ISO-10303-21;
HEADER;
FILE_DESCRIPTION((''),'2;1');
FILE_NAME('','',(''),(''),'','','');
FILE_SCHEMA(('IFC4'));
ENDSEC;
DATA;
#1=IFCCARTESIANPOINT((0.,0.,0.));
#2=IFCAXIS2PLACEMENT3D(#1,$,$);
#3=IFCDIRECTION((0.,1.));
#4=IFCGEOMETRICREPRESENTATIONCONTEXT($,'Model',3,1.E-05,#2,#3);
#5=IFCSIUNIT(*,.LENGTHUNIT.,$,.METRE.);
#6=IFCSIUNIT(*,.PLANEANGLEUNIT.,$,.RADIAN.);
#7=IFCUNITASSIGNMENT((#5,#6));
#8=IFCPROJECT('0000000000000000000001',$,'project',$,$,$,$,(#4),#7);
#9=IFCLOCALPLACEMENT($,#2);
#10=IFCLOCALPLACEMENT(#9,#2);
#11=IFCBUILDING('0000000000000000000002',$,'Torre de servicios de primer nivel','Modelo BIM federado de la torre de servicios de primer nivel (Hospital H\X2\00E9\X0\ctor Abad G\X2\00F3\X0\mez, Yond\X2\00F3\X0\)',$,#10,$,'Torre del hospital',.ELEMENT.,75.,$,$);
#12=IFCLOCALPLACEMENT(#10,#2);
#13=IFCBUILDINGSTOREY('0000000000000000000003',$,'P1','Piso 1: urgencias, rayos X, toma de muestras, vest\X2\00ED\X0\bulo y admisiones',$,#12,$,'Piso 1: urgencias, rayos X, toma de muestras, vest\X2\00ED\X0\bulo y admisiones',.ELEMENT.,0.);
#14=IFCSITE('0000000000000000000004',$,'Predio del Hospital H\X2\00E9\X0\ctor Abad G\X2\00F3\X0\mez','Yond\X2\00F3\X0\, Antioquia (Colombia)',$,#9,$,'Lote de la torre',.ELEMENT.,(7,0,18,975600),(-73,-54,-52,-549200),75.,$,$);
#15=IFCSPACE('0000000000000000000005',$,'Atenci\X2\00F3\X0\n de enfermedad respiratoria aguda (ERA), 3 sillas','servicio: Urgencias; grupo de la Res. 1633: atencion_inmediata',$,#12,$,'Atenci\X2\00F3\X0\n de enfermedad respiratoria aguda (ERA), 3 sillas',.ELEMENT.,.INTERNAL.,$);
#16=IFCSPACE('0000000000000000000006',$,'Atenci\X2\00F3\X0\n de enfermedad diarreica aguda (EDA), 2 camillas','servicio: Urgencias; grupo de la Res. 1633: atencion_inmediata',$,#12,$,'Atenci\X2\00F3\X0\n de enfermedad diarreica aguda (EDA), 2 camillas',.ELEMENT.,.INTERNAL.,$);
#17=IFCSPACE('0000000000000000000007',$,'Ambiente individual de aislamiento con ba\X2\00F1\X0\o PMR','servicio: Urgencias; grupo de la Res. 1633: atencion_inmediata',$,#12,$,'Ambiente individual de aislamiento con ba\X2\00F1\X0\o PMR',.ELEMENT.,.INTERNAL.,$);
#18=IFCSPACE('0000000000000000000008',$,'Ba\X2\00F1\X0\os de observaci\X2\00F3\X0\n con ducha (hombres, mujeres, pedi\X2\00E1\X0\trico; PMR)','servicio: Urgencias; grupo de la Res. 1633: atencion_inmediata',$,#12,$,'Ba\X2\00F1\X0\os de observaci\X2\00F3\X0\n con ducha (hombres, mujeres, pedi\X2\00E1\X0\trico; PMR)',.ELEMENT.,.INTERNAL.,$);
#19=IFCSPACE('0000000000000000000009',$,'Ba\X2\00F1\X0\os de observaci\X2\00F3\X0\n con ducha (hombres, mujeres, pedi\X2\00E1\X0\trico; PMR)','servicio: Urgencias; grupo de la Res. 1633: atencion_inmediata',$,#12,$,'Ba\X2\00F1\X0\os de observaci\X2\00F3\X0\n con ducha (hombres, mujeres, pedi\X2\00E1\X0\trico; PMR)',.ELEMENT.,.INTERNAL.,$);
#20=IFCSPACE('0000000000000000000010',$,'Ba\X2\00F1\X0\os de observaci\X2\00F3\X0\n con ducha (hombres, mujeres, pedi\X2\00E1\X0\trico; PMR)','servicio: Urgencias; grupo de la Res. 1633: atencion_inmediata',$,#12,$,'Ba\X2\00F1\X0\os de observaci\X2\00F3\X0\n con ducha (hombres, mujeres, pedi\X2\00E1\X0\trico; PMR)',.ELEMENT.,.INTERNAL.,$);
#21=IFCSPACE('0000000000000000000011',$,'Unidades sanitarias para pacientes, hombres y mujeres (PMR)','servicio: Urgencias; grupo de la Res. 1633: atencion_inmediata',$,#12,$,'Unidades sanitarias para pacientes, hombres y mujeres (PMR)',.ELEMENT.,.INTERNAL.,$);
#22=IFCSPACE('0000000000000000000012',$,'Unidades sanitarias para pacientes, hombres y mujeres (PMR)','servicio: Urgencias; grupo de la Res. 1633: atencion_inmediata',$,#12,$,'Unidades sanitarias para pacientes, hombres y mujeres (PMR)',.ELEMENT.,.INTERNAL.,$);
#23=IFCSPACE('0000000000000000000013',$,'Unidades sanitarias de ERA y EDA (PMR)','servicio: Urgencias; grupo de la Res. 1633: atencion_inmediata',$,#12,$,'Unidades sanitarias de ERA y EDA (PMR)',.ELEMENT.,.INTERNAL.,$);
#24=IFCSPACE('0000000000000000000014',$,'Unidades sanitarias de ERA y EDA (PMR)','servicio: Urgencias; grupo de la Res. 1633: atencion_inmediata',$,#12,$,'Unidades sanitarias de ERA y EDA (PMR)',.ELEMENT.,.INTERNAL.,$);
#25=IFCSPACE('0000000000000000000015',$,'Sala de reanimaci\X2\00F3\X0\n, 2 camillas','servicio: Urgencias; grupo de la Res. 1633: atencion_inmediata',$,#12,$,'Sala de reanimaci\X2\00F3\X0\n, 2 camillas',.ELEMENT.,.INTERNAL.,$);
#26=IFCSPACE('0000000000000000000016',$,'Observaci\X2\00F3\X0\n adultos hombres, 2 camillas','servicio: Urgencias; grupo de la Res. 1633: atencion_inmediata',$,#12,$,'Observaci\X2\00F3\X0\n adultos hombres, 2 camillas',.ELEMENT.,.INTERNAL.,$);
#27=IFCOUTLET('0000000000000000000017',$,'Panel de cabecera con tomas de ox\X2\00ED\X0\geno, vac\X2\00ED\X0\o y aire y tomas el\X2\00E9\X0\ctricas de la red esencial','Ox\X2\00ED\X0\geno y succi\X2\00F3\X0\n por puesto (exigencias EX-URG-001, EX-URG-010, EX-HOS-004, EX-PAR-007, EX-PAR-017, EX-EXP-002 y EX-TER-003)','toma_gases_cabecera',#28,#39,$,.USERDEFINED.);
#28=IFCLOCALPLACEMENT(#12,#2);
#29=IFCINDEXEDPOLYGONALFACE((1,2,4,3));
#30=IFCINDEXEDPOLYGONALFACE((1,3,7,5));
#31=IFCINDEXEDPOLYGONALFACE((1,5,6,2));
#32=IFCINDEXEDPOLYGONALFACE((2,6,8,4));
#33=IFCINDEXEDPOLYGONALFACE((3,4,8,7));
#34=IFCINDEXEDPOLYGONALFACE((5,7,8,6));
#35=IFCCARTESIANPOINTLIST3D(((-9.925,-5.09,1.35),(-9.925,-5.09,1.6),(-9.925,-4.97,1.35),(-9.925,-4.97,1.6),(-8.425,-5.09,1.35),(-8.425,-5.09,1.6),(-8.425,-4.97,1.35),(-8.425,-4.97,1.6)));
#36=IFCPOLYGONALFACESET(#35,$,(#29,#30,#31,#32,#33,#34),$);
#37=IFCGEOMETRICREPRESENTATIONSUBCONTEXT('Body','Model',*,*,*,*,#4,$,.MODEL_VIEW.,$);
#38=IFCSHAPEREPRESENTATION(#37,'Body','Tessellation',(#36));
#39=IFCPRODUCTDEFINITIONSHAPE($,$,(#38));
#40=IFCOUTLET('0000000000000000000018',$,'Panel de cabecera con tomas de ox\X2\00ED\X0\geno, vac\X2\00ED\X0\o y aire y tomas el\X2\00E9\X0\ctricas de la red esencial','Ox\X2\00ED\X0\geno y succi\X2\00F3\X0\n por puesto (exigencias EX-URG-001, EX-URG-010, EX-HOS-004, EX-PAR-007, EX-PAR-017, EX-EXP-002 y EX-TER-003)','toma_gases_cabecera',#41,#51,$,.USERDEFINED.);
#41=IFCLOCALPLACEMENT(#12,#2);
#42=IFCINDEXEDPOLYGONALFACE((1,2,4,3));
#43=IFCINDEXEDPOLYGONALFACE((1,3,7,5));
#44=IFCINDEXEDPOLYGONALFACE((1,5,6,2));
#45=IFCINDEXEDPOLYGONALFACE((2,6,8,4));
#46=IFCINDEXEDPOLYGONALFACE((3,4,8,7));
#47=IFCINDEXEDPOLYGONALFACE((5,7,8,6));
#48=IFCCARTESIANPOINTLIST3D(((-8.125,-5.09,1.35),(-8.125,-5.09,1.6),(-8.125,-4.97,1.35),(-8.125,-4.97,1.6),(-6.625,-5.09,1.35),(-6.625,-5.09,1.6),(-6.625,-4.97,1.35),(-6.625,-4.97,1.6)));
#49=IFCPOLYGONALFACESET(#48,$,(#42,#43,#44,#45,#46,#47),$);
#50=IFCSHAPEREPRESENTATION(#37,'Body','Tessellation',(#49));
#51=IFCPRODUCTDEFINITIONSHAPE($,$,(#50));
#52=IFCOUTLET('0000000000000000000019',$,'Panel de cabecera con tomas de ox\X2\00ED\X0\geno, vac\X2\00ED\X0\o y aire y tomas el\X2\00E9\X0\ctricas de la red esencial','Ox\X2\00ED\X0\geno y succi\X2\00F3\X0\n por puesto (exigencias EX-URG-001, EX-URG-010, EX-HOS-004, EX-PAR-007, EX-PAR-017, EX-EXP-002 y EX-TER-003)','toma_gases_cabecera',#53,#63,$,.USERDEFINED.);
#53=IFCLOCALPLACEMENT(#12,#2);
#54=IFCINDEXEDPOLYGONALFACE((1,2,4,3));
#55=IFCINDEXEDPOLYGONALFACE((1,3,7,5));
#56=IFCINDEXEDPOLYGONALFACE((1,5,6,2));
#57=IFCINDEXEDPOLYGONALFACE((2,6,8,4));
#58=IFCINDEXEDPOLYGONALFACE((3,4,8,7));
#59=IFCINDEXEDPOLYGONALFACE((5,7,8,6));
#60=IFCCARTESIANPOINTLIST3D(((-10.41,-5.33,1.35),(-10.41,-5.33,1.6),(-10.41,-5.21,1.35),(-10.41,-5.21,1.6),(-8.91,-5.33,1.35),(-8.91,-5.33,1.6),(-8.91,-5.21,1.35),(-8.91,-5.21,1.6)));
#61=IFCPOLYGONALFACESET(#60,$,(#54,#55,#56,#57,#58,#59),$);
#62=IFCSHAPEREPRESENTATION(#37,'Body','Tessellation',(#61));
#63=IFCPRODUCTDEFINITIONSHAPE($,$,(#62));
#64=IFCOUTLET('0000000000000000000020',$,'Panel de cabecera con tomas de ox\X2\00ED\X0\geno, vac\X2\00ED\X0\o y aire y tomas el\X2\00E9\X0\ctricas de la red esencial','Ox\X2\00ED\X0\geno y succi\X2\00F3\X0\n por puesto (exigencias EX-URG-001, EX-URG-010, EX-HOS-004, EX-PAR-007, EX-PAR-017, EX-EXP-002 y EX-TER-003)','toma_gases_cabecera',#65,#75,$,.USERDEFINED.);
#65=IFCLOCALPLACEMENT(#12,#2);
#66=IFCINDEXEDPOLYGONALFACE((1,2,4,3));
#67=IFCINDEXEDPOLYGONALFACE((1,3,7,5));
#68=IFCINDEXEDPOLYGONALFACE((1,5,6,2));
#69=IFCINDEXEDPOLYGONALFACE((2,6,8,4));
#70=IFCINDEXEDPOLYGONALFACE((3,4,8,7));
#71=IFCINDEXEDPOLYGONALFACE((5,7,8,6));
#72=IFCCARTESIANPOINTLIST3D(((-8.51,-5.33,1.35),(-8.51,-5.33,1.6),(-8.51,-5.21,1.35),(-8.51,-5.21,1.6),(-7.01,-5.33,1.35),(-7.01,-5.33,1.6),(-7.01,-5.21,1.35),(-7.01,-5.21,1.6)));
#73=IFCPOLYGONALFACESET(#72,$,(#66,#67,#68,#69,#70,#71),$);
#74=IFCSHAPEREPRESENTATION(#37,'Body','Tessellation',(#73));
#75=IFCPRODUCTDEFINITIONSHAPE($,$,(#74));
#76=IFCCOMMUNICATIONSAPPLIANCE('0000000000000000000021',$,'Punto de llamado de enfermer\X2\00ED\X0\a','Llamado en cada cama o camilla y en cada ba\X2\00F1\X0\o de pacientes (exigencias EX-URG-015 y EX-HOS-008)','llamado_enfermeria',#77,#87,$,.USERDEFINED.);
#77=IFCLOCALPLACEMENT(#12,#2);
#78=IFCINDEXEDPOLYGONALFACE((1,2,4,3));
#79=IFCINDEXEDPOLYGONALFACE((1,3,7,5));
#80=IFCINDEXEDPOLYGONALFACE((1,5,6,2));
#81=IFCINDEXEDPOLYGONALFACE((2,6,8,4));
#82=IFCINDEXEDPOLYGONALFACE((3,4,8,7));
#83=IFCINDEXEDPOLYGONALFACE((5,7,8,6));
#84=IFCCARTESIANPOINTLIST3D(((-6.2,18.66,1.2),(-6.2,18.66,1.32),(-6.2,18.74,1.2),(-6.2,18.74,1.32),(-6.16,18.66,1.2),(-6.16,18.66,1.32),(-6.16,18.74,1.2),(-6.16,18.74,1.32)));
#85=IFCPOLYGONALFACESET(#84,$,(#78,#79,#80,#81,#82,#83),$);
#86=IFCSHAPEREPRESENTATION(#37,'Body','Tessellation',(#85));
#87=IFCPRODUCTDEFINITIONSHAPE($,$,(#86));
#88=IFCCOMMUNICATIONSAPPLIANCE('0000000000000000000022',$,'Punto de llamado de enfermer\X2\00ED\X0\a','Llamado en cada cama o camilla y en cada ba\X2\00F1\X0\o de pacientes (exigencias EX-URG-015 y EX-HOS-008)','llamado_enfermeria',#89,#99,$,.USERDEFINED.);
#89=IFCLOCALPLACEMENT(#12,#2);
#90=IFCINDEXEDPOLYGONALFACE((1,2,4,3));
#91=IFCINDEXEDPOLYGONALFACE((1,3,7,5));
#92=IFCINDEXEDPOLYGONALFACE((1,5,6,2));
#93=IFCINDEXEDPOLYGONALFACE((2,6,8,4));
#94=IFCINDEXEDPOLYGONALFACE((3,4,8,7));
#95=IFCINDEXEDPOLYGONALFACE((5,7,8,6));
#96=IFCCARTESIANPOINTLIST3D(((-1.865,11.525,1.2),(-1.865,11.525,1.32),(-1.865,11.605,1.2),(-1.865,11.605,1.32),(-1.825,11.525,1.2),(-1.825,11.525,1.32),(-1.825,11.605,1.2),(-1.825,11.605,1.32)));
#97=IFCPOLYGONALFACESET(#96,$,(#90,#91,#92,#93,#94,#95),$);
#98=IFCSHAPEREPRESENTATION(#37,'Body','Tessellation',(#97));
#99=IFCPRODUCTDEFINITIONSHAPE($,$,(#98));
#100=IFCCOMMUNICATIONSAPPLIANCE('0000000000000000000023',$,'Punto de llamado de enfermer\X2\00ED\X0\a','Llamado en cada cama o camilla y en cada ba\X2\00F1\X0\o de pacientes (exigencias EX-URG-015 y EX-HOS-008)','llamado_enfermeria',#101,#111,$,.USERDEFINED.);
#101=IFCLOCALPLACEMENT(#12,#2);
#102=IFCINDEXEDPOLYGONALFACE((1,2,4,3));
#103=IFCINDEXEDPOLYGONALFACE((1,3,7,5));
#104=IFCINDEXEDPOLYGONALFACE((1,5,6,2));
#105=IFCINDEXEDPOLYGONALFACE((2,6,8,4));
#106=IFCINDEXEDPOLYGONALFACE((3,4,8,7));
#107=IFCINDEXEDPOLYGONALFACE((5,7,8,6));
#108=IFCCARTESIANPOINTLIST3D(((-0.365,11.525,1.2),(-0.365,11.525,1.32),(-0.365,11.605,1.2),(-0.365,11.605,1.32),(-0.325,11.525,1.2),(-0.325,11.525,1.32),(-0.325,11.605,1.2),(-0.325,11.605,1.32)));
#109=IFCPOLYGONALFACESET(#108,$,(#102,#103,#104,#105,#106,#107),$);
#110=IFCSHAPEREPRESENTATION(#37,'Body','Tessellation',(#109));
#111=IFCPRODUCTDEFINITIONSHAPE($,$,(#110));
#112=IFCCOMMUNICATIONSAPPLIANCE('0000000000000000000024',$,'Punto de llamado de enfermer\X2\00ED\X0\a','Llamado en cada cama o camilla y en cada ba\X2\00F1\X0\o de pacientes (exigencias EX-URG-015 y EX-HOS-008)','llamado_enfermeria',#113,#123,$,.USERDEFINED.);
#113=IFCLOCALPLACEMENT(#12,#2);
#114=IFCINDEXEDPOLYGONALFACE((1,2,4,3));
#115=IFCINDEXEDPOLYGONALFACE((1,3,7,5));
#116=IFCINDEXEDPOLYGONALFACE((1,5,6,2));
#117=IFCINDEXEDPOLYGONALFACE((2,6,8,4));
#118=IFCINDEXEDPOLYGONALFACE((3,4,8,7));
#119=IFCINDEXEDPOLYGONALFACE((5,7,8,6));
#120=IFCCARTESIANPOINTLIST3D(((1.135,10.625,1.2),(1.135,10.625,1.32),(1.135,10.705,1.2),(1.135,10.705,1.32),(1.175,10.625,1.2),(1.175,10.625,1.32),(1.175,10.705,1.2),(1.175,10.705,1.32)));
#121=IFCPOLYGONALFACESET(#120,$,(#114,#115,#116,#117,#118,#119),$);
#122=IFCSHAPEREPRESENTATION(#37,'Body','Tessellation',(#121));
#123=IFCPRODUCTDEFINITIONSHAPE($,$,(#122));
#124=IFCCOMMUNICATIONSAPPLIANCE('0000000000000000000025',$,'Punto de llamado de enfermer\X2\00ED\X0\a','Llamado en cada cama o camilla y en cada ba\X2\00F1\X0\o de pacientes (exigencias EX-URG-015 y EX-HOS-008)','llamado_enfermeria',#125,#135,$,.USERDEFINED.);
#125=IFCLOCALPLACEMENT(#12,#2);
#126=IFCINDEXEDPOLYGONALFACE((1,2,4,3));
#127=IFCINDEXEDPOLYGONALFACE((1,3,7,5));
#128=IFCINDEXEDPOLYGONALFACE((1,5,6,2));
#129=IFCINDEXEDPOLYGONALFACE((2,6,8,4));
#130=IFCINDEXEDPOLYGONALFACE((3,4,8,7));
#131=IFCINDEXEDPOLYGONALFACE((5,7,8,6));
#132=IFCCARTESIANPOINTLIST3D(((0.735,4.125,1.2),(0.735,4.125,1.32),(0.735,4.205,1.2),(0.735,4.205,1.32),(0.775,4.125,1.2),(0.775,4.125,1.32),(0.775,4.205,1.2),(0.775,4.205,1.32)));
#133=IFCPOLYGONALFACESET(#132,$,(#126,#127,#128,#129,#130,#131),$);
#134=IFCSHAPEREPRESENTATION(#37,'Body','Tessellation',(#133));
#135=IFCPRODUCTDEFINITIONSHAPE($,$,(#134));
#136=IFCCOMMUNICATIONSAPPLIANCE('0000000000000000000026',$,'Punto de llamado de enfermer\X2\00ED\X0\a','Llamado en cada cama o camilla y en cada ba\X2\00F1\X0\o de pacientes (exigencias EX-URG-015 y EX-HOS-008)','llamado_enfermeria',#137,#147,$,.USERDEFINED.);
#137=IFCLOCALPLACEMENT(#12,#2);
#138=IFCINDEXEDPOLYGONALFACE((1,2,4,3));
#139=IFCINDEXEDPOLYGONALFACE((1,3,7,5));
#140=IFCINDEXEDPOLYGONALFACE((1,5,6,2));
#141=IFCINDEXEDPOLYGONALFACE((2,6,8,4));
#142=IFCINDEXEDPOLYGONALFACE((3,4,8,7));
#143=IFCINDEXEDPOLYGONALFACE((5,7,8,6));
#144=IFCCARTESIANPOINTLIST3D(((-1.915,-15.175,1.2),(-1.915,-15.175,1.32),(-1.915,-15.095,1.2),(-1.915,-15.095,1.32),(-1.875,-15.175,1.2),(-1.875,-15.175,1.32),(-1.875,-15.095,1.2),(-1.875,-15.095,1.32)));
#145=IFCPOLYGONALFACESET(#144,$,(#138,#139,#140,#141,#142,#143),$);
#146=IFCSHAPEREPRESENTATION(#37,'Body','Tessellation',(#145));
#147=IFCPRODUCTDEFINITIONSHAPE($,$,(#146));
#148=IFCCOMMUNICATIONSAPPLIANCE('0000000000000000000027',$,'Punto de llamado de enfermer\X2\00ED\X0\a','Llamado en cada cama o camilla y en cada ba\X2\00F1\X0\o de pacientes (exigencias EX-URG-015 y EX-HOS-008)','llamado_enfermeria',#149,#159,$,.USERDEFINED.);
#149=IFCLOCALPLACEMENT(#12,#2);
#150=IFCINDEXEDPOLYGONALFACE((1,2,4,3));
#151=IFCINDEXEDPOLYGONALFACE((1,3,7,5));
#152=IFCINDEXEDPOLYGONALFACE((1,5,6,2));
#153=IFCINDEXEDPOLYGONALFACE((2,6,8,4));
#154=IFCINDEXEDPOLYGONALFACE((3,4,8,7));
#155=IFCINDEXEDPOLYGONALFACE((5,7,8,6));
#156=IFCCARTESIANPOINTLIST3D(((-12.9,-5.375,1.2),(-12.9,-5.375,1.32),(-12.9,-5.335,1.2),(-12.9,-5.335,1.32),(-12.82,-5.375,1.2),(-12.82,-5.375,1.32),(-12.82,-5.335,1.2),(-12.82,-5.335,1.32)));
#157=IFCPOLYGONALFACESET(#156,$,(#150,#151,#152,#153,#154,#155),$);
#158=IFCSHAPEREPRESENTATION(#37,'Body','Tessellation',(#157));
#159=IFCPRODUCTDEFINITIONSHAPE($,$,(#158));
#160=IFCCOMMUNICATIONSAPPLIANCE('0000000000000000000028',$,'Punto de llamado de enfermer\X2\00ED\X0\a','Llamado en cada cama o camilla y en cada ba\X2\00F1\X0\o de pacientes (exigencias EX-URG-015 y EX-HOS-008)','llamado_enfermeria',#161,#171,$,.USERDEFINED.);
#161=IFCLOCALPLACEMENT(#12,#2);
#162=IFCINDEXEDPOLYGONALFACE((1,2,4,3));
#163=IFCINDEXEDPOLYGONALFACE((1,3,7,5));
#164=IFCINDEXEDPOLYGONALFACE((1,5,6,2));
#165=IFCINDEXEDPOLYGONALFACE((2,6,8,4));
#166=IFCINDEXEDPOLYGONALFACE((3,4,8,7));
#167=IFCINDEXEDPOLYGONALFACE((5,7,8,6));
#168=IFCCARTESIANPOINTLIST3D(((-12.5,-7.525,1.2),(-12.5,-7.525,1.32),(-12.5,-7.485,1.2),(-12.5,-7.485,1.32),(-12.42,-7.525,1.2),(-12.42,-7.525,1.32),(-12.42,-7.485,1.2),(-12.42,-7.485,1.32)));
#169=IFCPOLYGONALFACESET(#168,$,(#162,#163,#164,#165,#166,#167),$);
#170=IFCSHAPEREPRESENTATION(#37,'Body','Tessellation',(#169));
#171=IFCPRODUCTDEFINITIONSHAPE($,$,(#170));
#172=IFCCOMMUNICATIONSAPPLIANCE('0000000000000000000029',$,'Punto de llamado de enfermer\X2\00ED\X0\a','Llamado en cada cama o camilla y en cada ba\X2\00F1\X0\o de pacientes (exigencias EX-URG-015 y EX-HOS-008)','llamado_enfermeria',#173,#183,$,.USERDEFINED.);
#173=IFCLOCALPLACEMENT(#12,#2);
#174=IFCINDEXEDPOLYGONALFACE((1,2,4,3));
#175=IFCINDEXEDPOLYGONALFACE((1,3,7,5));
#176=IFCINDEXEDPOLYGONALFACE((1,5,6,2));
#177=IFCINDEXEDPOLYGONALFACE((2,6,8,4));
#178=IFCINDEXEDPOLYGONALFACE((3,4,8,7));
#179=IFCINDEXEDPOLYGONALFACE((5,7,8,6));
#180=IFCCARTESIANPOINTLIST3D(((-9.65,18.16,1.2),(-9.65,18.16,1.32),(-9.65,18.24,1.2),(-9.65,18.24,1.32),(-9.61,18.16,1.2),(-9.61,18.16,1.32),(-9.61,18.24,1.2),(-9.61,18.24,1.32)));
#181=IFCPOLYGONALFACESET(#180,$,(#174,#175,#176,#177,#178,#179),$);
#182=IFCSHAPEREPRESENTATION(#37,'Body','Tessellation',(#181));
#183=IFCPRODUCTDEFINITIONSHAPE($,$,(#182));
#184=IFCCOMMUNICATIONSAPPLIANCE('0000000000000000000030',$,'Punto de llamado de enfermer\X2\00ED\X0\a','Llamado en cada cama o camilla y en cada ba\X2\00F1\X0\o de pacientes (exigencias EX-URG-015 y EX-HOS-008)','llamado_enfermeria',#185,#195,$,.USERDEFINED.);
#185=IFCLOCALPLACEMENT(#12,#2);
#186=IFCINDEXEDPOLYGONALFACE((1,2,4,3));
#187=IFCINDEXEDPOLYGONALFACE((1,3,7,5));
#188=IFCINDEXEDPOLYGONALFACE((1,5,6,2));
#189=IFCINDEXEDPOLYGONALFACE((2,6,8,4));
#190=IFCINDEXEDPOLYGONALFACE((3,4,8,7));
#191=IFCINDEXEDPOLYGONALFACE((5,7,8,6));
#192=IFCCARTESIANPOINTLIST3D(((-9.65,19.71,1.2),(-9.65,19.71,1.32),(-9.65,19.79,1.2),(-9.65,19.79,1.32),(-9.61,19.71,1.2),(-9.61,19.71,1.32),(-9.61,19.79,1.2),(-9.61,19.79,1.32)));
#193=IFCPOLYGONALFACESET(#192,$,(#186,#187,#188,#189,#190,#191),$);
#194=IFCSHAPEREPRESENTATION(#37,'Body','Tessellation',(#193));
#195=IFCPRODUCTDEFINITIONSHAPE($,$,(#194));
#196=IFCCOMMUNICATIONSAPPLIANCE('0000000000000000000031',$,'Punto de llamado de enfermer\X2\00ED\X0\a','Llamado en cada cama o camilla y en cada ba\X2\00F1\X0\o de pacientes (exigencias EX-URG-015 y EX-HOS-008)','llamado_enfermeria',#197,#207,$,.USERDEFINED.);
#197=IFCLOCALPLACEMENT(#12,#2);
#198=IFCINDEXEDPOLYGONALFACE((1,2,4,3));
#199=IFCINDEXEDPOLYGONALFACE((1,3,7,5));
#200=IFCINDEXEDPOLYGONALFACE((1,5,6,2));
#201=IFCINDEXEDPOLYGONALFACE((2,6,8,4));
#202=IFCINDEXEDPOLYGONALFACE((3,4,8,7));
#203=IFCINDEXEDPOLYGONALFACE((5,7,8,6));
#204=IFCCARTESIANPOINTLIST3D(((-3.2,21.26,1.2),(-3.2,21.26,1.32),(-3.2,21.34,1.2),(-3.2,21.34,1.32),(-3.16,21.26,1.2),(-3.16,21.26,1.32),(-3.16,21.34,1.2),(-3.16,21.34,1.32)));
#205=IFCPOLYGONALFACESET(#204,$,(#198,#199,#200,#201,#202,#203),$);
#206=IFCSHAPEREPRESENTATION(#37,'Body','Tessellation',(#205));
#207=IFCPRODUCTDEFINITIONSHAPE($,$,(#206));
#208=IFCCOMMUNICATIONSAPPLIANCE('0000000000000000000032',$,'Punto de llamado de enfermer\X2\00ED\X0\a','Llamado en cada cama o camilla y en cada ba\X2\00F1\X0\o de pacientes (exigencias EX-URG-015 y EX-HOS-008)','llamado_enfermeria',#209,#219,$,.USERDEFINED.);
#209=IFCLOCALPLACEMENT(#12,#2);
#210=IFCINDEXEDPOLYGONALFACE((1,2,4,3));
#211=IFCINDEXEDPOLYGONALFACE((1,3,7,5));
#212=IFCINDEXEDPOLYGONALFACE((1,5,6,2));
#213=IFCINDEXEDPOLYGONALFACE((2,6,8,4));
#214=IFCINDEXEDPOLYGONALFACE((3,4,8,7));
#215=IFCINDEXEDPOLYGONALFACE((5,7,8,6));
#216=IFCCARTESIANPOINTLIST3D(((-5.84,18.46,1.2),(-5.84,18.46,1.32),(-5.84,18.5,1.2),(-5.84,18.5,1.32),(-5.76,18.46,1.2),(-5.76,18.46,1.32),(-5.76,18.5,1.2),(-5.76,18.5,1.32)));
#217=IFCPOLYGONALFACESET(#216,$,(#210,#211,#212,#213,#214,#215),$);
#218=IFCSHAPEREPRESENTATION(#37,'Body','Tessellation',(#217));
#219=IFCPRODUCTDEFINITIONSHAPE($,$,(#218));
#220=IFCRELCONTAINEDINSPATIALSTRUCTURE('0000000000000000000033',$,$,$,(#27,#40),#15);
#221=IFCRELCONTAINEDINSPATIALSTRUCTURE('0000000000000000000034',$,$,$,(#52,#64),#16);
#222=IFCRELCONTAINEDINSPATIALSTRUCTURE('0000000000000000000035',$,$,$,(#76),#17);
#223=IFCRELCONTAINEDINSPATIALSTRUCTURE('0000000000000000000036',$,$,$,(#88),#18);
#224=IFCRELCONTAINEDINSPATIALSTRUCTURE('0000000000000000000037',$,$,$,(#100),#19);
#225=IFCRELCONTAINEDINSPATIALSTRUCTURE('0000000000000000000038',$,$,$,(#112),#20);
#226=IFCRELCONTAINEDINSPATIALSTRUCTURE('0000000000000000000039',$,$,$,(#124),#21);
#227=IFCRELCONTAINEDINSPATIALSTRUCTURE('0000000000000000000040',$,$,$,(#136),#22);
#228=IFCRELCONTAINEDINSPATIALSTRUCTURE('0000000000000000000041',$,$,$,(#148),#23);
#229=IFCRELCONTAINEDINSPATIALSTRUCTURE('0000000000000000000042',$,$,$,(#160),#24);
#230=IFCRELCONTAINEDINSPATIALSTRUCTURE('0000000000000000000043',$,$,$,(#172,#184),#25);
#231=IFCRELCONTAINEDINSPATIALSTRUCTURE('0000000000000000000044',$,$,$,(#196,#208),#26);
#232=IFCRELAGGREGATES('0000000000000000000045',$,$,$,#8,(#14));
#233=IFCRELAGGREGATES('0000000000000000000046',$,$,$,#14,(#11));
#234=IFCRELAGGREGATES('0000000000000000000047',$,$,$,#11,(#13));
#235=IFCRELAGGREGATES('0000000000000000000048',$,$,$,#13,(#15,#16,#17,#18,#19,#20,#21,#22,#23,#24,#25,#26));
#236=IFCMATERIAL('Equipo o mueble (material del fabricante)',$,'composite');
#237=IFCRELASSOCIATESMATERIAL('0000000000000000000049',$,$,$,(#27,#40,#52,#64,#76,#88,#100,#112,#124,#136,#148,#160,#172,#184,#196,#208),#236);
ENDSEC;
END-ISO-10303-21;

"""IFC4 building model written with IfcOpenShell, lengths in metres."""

from ifc_helpers import new_model, si_unit, direction, frame, origin, place, context, subcontext, project, spatial, rectangle, extrude, material, element, save


model = new_model("IFC4")

# Units and contexts
model_context = context("Model", 3, precision=1e-05, world=origin(), true_north=direction((0.0, 1.0)))
body_context = subcontext(model_context, "Body", "Model", "MODEL_VIEW")
ifc_project = project(units=[si_unit("LENGTHUNIT", "METRE"), si_unit("PLANEANGLEUNIT", "RADIAN")], contexts=[model_context])

# Site, building, storey, space
site_placement = place(None, origin())
site = spatial("IfcSite", under=ifc_project, at=site_placement, Name="Predio del Hospital Héctor Abad Gómez", Description="Yondó, Antioquia (Colombia)", LongName="Lote de la torre", CompositionType="ELEMENT", RefLatitude=(7, 0, 18, 975600), RefLongitude=(-73, -54, -52, -549200), RefElevation=75.0)
building_placement = place(site_placement, origin())
building = spatial("IfcBuilding", under=site, at=building_placement, Name="Torre de servicios de primer nivel", Description="Modelo BIM federado de la torre de servicios de primer nivel (Hospital Héctor Abad Gómez, Yondó)", LongName="Torre del hospital", CompositionType="ELEMENT", ElevationOfRefHeight=75.0)
placement = place(building_placement, origin())
storey = spatial("IfcBuildingStorey", under=building, at=placement, Name="P1", Description="Piso 1: urgencias, rayos X, toma de muestras, vestíbulo y admisiones", LongName="Piso 1: urgencias, rayos X, toma de muestras, vestíbulo y admisiones", CompositionType="ELEMENT", Elevation=0.0)
space_1 = spatial("IfcSpace", under=storey, at=placement, Name="Atención de enfermedad respiratoria aguda (ERA), 3 sillas", Description="servicio: Urgencias; grupo de la Res. 1633: atencion_inmediata", LongName="Atención de enfermedad respiratoria aguda (ERA), 3 sillas", CompositionType="ELEMENT", PredefinedType="INTERNAL")

# Outlets
ifc_material = material(Name="Equipo o mueble (material del fabricante)", Category="composite")
element("IfcOutlet", 1, at=placement, inside=space_1, material=ifc_material, Name="Panel de cabecera con tomas de oxígeno, vacío y aire y tomas eléctricas de la red esencial", Description="Oxígeno y succión por puesto (exigencias EX-URG-001, EX-URG-010, EX-HOS-004, EX-PAR-007, EX-PAR-017, EX-EXP-002 y EX-TER-003)", ObjectType="toma_gases_cabecera", PredefinedType="USERDEFINED", context=body_context, shape_type="SweptSolid", body=[
    extrude(rectangle(XDim=1.5, YDim=0.12), frame((-9.175, -5.03, 1.35)), (0.0, 0.0, 1.0), 0.25),
])
element("IfcOutlet", 2, at=placement, inside=space_1, material=ifc_material, Name="Panel de cabecera con tomas de oxígeno, vacío y aire y tomas eléctricas de la red esencial", Description="Oxígeno y succión por puesto (exigencias EX-URG-001, EX-URG-010, EX-HOS-004, EX-PAR-007, EX-PAR-017, EX-EXP-002 y EX-TER-003)", ObjectType="toma_gases_cabecera", PredefinedType="USERDEFINED", context=body_context, shape_type="SweptSolid", body=[
    extrude(rectangle(XDim=1.5, YDim=0.12), frame((-7.375, -5.03, 1.35)), (0.0, 0.0, 1.0), 0.25),
])

# Shared definitions
space_2 = spatial("IfcSpace", under=storey, at=placement, Name="Atención de enfermedad diarreica aguda (EDA), 2 camillas", Description="servicio: Urgencias; grupo de la Res. 1633: atencion_inmediata", LongName="Atención de enfermedad diarreica aguda (EDA), 2 camillas", CompositionType="ELEMENT", PredefinedType="INTERNAL")

# Outlets
element("IfcOutlet", 3, at=placement, inside=space_2, material=ifc_material, Name="Panel de cabecera con tomas de oxígeno, vacío y aire y tomas eléctricas de la red esencial", Description="Oxígeno y succión por puesto (exigencias EX-URG-001, EX-URG-010, EX-HOS-004, EX-PAR-007, EX-PAR-017, EX-EXP-002 y EX-TER-003)", ObjectType="toma_gases_cabecera", PredefinedType="USERDEFINED", context=body_context, shape_type="SweptSolid", body=[
    extrude(rectangle(XDim=1.5, YDim=0.12), frame((-9.66, -5.27, 1.35), z_axis=(0.0, 0.0, 1.0), x_axis=(-1.0, 0.0, 0.0)), (0.0, 0.0, 1.0), 0.25),
])
element("IfcOutlet", 4, at=placement, inside=space_2, material=ifc_material, Name="Panel de cabecera con tomas de oxígeno, vacío y aire y tomas eléctricas de la red esencial", Description="Oxígeno y succión por puesto (exigencias EX-URG-001, EX-URG-010, EX-HOS-004, EX-PAR-007, EX-PAR-017, EX-EXP-002 y EX-TER-003)", ObjectType="toma_gases_cabecera", PredefinedType="USERDEFINED", context=body_context, shape_type="SweptSolid", body=[
    extrude(rectangle(XDim=1.5, YDim=0.12), frame((-7.76, -5.27, 1.35), z_axis=(0.0, 0.0, 1.0), x_axis=(-1.0, 0.0, 0.0)), (0.0, 0.0, 1.0), 0.25),
])

# Shared definitions
space_3 = spatial("IfcSpace", under=storey, at=placement, Name="Ambiente individual de aislamiento con baño PMR", Description="servicio: Urgencias; grupo de la Res. 1633: atencion_inmediata", LongName="Ambiente individual de aislamiento con baño PMR", CompositionType="ELEMENT", PredefinedType="INTERNAL")

# Communications appliance
element("IfcCommunicationsAppliance", 5, at=placement, inside=space_3, material=ifc_material, Name="Punto de llamado de enfermería", Description="Llamado en cada cama o camilla y en cada baño de pacientes (exigencias EX-URG-015 y EX-HOS-008)", ObjectType="llamado_enfermeria", PredefinedType="USERDEFINED", context=body_context, shape_type="SweptSolid", body=[
    extrude(rectangle(XDim=0.08, YDim=0.04), frame((-6.18, 18.7, 1.2), z_axis=(0.0, 0.0, 1.0), x_axis=(0.0, 1.0, 0.0)), (0.0, 0.0, 1.0), 0.12),
])

# Shared definitions
space_4 = spatial("IfcSpace", under=storey, at=placement, Name="Baños de observación con ducha (hombres, mujeres, pediátrico; PMR)", Description="servicio: Urgencias; grupo de la Res. 1633: atencion_inmediata", LongName="Baños de observación con ducha (hombres, mujeres, pediátrico; PMR)", CompositionType="ELEMENT", PredefinedType="INTERNAL")

# Communications appliance
element("IfcCommunicationsAppliance", 6, at=placement, inside=space_4, material=ifc_material, Name="Punto de llamado de enfermería", Description="Llamado en cada cama o camilla y en cada baño de pacientes (exigencias EX-URG-015 y EX-HOS-008)", ObjectType="llamado_enfermeria", PredefinedType="USERDEFINED", context=body_context, shape_type="SweptSolid", body=[
    extrude(rectangle(XDim=0.08, YDim=0.04), frame((-1.845, 11.565, 1.2), z_axis=(0.0, 0.0, 1.0), x_axis=(0.0, 1.0, 0.0)), (0.0, 0.0, 1.0), 0.12),
])

# Shared definitions
space_5 = spatial("IfcSpace", under=storey, at=placement, Name="Baños de observación con ducha (hombres, mujeres, pediátrico; PMR)", Description="servicio: Urgencias; grupo de la Res. 1633: atencion_inmediata", LongName="Baños de observación con ducha (hombres, mujeres, pediátrico; PMR)", CompositionType="ELEMENT", PredefinedType="INTERNAL")

# Communications appliance
element("IfcCommunicationsAppliance", 7, at=placement, inside=space_5, material=ifc_material, Name="Punto de llamado de enfermería", Description="Llamado en cada cama o camilla y en cada baño de pacientes (exigencias EX-URG-015 y EX-HOS-008)", ObjectType="llamado_enfermeria", PredefinedType="USERDEFINED", context=body_context, shape_type="SweptSolid", body=[
    extrude(rectangle(XDim=0.08, YDim=0.04), frame((-0.345, 11.565, 1.2), z_axis=(0.0, 0.0, 1.0), x_axis=(0.0, 1.0, 0.0)), (0.0, 0.0, 1.0), 0.12),
])

# Shared definitions
space_6 = spatial("IfcSpace", under=storey, at=placement, Name="Baños de observación con ducha (hombres, mujeres, pediátrico; PMR)", Description="servicio: Urgencias; grupo de la Res. 1633: atencion_inmediata", LongName="Baños de observación con ducha (hombres, mujeres, pediátrico; PMR)", CompositionType="ELEMENT", PredefinedType="INTERNAL")

# Communications appliance
element("IfcCommunicationsAppliance", 8, at=placement, inside=space_6, material=ifc_material, Name="Punto de llamado de enfermería", Description="Llamado en cada cama o camilla y en cada baño de pacientes (exigencias EX-URG-015 y EX-HOS-008)", ObjectType="llamado_enfermeria", PredefinedType="USERDEFINED", context=body_context, shape_type="SweptSolid", body=[
    extrude(rectangle(XDim=0.08, YDim=0.04), frame((1.155, 10.665, 1.2), z_axis=(0.0, 0.0, 1.0), x_axis=(0.0, 1.0, 0.0)), (0.0, 0.0, 1.0), 0.12),
])

# Shared definitions
space_7 = spatial("IfcSpace", under=storey, at=placement, Name="Unidades sanitarias para pacientes, hombres y mujeres (PMR)", Description="servicio: Urgencias; grupo de la Res. 1633: atencion_inmediata", LongName="Unidades sanitarias para pacientes, hombres y mujeres (PMR)", CompositionType="ELEMENT", PredefinedType="INTERNAL")

# Communications appliance
element("IfcCommunicationsAppliance", 9, at=placement, inside=space_7, material=ifc_material, Name="Punto de llamado de enfermería", Description="Llamado en cada cama o camilla y en cada baño de pacientes (exigencias EX-URG-015 y EX-HOS-008)", ObjectType="llamado_enfermeria", PredefinedType="USERDEFINED", context=body_context, shape_type="SweptSolid", body=[
    extrude(rectangle(XDim=0.08, YDim=0.04), frame((0.755, 4.165, 1.2), z_axis=(0.0, 0.0, 1.0), x_axis=(0.0, 1.0, 0.0)), (0.0, 0.0, 1.0), 0.12),
])

# Shared definitions
space_8 = spatial("IfcSpace", under=storey, at=placement, Name="Unidades sanitarias para pacientes, hombres y mujeres (PMR)", Description="servicio: Urgencias; grupo de la Res. 1633: atencion_inmediata", LongName="Unidades sanitarias para pacientes, hombres y mujeres (PMR)", CompositionType="ELEMENT", PredefinedType="INTERNAL")

# Communications appliance
element("IfcCommunicationsAppliance", 10, at=placement, inside=space_8, material=ifc_material, Name="Punto de llamado de enfermería", Description="Llamado en cada cama o camilla y en cada baño de pacientes (exigencias EX-URG-015 y EX-HOS-008)", ObjectType="llamado_enfermeria", PredefinedType="USERDEFINED", context=body_context, shape_type="SweptSolid", body=[
    extrude(rectangle(XDim=0.08, YDim=0.04), frame((-1.895, -15.135, 1.2), z_axis=(0.0, 0.0, 1.0), x_axis=(0.0, 1.0, 0.0)), (0.0, 0.0, 1.0), 0.12),
])

# Shared definitions
space_9 = spatial("IfcSpace", under=storey, at=placement, Name="Unidades sanitarias de ERA y EDA (PMR)", Description="servicio: Urgencias; grupo de la Res. 1633: atencion_inmediata", LongName="Unidades sanitarias de ERA y EDA (PMR)", CompositionType="ELEMENT", PredefinedType="INTERNAL")

# Communications appliance
element("IfcCommunicationsAppliance", 11, at=placement, inside=space_9, material=ifc_material, Name="Punto de llamado de enfermería", Description="Llamado en cada cama o camilla y en cada baño de pacientes (exigencias EX-URG-015 y EX-HOS-008)", ObjectType="llamado_enfermeria", PredefinedType="USERDEFINED", context=body_context, shape_type="SweptSolid", body=[
    extrude(rectangle(XDim=0.08, YDim=0.04), frame((-12.86, -5.355, 1.2)), (0.0, 0.0, 1.0), 0.12),
])

# Shared definitions
space_10 = spatial("IfcSpace", under=storey, at=placement, Name="Unidades sanitarias de ERA y EDA (PMR)", Description="servicio: Urgencias; grupo de la Res. 1633: atencion_inmediata", LongName="Unidades sanitarias de ERA y EDA (PMR)", CompositionType="ELEMENT", PredefinedType="INTERNAL")

# Communications appliance
element("IfcCommunicationsAppliance", 12, at=placement, inside=space_10, material=ifc_material, Name="Punto de llamado de enfermería", Description="Llamado en cada cama o camilla y en cada baño de pacientes (exigencias EX-URG-015 y EX-HOS-008)", ObjectType="llamado_enfermeria", PredefinedType="USERDEFINED", context=body_context, shape_type="SweptSolid", body=[
    extrude(rectangle(XDim=0.08, YDim=0.04), frame((-12.46, -7.505, 1.2)), (0.0, 0.0, 1.0), 0.12),
])

# Shared definitions
space_11 = spatial("IfcSpace", under=storey, at=placement, Name="Sala de reanimación, 2 camillas", Description="servicio: Urgencias; grupo de la Res. 1633: atencion_inmediata", LongName="Sala de reanimación, 2 camillas", CompositionType="ELEMENT", PredefinedType="INTERNAL")

# Communications appliances
element("IfcCommunicationsAppliance", 13, at=placement, inside=space_11, material=ifc_material, Name="Punto de llamado de enfermería", Description="Llamado en cada cama o camilla y en cada baño de pacientes (exigencias EX-URG-015 y EX-HOS-008)", ObjectType="llamado_enfermeria", PredefinedType="USERDEFINED", context=body_context, shape_type="SweptSolid", body=[
    extrude(rectangle(XDim=0.08, YDim=0.04), frame((-9.63, 18.2, 1.2), z_axis=(0.0, 0.0, 1.0), x_axis=(0.0, 1.0, 0.0)), (0.0, 0.0, 1.0), 0.12),
])
element("IfcCommunicationsAppliance", 14, at=placement, inside=space_11, material=ifc_material, Name="Punto de llamado de enfermería", Description="Llamado en cada cama o camilla y en cada baño de pacientes (exigencias EX-URG-015 y EX-HOS-008)", ObjectType="llamado_enfermeria", PredefinedType="USERDEFINED", context=body_context, shape_type="SweptSolid", body=[
    extrude(rectangle(XDim=0.08, YDim=0.04), frame((-9.63, 19.75, 1.2), z_axis=(0.0, 0.0, 1.0), x_axis=(0.0, 1.0, 0.0)), (0.0, 0.0, 1.0), 0.12),
])

# Shared definitions
space_12 = spatial("IfcSpace", under=storey, at=placement, Name="Observación adultos hombres, 2 camillas", Description="servicio: Urgencias; grupo de la Res. 1633: atencion_inmediata", LongName="Observación adultos hombres, 2 camillas", CompositionType="ELEMENT", PredefinedType="INTERNAL")

# Communications appliances
element("IfcCommunicationsAppliance", 15, at=placement, inside=space_12, material=ifc_material, Name="Punto de llamado de enfermería", Description="Llamado en cada cama o camilla y en cada baño de pacientes (exigencias EX-URG-015 y EX-HOS-008)", ObjectType="llamado_enfermeria", PredefinedType="USERDEFINED", context=body_context, shape_type="SweptSolid", body=[
    extrude(rectangle(XDim=0.08, YDim=0.04), frame((-3.18, 21.3, 1.2), z_axis=(0.0, 0.0, 1.0), x_axis=(0.0, 1.0, 0.0)), (0.0, 0.0, 1.0), 0.12),
])
element("IfcCommunicationsAppliance", 16, at=placement, inside=space_12, material=ifc_material, Name="Punto de llamado de enfermería", Description="Llamado en cada cama o camilla y en cada baño de pacientes (exigencias EX-URG-015 y EX-HOS-008)", ObjectType="llamado_enfermeria", PredefinedType="USERDEFINED", context=body_context, shape_type="SweptSolid", body=[
    extrude(rectangle(XDim=0.08, YDim=0.04), frame((-5.8, 18.48, 1.2)), (0.0, 0.0, 1.0), 0.12),
])

save(model, "model.ifc")
